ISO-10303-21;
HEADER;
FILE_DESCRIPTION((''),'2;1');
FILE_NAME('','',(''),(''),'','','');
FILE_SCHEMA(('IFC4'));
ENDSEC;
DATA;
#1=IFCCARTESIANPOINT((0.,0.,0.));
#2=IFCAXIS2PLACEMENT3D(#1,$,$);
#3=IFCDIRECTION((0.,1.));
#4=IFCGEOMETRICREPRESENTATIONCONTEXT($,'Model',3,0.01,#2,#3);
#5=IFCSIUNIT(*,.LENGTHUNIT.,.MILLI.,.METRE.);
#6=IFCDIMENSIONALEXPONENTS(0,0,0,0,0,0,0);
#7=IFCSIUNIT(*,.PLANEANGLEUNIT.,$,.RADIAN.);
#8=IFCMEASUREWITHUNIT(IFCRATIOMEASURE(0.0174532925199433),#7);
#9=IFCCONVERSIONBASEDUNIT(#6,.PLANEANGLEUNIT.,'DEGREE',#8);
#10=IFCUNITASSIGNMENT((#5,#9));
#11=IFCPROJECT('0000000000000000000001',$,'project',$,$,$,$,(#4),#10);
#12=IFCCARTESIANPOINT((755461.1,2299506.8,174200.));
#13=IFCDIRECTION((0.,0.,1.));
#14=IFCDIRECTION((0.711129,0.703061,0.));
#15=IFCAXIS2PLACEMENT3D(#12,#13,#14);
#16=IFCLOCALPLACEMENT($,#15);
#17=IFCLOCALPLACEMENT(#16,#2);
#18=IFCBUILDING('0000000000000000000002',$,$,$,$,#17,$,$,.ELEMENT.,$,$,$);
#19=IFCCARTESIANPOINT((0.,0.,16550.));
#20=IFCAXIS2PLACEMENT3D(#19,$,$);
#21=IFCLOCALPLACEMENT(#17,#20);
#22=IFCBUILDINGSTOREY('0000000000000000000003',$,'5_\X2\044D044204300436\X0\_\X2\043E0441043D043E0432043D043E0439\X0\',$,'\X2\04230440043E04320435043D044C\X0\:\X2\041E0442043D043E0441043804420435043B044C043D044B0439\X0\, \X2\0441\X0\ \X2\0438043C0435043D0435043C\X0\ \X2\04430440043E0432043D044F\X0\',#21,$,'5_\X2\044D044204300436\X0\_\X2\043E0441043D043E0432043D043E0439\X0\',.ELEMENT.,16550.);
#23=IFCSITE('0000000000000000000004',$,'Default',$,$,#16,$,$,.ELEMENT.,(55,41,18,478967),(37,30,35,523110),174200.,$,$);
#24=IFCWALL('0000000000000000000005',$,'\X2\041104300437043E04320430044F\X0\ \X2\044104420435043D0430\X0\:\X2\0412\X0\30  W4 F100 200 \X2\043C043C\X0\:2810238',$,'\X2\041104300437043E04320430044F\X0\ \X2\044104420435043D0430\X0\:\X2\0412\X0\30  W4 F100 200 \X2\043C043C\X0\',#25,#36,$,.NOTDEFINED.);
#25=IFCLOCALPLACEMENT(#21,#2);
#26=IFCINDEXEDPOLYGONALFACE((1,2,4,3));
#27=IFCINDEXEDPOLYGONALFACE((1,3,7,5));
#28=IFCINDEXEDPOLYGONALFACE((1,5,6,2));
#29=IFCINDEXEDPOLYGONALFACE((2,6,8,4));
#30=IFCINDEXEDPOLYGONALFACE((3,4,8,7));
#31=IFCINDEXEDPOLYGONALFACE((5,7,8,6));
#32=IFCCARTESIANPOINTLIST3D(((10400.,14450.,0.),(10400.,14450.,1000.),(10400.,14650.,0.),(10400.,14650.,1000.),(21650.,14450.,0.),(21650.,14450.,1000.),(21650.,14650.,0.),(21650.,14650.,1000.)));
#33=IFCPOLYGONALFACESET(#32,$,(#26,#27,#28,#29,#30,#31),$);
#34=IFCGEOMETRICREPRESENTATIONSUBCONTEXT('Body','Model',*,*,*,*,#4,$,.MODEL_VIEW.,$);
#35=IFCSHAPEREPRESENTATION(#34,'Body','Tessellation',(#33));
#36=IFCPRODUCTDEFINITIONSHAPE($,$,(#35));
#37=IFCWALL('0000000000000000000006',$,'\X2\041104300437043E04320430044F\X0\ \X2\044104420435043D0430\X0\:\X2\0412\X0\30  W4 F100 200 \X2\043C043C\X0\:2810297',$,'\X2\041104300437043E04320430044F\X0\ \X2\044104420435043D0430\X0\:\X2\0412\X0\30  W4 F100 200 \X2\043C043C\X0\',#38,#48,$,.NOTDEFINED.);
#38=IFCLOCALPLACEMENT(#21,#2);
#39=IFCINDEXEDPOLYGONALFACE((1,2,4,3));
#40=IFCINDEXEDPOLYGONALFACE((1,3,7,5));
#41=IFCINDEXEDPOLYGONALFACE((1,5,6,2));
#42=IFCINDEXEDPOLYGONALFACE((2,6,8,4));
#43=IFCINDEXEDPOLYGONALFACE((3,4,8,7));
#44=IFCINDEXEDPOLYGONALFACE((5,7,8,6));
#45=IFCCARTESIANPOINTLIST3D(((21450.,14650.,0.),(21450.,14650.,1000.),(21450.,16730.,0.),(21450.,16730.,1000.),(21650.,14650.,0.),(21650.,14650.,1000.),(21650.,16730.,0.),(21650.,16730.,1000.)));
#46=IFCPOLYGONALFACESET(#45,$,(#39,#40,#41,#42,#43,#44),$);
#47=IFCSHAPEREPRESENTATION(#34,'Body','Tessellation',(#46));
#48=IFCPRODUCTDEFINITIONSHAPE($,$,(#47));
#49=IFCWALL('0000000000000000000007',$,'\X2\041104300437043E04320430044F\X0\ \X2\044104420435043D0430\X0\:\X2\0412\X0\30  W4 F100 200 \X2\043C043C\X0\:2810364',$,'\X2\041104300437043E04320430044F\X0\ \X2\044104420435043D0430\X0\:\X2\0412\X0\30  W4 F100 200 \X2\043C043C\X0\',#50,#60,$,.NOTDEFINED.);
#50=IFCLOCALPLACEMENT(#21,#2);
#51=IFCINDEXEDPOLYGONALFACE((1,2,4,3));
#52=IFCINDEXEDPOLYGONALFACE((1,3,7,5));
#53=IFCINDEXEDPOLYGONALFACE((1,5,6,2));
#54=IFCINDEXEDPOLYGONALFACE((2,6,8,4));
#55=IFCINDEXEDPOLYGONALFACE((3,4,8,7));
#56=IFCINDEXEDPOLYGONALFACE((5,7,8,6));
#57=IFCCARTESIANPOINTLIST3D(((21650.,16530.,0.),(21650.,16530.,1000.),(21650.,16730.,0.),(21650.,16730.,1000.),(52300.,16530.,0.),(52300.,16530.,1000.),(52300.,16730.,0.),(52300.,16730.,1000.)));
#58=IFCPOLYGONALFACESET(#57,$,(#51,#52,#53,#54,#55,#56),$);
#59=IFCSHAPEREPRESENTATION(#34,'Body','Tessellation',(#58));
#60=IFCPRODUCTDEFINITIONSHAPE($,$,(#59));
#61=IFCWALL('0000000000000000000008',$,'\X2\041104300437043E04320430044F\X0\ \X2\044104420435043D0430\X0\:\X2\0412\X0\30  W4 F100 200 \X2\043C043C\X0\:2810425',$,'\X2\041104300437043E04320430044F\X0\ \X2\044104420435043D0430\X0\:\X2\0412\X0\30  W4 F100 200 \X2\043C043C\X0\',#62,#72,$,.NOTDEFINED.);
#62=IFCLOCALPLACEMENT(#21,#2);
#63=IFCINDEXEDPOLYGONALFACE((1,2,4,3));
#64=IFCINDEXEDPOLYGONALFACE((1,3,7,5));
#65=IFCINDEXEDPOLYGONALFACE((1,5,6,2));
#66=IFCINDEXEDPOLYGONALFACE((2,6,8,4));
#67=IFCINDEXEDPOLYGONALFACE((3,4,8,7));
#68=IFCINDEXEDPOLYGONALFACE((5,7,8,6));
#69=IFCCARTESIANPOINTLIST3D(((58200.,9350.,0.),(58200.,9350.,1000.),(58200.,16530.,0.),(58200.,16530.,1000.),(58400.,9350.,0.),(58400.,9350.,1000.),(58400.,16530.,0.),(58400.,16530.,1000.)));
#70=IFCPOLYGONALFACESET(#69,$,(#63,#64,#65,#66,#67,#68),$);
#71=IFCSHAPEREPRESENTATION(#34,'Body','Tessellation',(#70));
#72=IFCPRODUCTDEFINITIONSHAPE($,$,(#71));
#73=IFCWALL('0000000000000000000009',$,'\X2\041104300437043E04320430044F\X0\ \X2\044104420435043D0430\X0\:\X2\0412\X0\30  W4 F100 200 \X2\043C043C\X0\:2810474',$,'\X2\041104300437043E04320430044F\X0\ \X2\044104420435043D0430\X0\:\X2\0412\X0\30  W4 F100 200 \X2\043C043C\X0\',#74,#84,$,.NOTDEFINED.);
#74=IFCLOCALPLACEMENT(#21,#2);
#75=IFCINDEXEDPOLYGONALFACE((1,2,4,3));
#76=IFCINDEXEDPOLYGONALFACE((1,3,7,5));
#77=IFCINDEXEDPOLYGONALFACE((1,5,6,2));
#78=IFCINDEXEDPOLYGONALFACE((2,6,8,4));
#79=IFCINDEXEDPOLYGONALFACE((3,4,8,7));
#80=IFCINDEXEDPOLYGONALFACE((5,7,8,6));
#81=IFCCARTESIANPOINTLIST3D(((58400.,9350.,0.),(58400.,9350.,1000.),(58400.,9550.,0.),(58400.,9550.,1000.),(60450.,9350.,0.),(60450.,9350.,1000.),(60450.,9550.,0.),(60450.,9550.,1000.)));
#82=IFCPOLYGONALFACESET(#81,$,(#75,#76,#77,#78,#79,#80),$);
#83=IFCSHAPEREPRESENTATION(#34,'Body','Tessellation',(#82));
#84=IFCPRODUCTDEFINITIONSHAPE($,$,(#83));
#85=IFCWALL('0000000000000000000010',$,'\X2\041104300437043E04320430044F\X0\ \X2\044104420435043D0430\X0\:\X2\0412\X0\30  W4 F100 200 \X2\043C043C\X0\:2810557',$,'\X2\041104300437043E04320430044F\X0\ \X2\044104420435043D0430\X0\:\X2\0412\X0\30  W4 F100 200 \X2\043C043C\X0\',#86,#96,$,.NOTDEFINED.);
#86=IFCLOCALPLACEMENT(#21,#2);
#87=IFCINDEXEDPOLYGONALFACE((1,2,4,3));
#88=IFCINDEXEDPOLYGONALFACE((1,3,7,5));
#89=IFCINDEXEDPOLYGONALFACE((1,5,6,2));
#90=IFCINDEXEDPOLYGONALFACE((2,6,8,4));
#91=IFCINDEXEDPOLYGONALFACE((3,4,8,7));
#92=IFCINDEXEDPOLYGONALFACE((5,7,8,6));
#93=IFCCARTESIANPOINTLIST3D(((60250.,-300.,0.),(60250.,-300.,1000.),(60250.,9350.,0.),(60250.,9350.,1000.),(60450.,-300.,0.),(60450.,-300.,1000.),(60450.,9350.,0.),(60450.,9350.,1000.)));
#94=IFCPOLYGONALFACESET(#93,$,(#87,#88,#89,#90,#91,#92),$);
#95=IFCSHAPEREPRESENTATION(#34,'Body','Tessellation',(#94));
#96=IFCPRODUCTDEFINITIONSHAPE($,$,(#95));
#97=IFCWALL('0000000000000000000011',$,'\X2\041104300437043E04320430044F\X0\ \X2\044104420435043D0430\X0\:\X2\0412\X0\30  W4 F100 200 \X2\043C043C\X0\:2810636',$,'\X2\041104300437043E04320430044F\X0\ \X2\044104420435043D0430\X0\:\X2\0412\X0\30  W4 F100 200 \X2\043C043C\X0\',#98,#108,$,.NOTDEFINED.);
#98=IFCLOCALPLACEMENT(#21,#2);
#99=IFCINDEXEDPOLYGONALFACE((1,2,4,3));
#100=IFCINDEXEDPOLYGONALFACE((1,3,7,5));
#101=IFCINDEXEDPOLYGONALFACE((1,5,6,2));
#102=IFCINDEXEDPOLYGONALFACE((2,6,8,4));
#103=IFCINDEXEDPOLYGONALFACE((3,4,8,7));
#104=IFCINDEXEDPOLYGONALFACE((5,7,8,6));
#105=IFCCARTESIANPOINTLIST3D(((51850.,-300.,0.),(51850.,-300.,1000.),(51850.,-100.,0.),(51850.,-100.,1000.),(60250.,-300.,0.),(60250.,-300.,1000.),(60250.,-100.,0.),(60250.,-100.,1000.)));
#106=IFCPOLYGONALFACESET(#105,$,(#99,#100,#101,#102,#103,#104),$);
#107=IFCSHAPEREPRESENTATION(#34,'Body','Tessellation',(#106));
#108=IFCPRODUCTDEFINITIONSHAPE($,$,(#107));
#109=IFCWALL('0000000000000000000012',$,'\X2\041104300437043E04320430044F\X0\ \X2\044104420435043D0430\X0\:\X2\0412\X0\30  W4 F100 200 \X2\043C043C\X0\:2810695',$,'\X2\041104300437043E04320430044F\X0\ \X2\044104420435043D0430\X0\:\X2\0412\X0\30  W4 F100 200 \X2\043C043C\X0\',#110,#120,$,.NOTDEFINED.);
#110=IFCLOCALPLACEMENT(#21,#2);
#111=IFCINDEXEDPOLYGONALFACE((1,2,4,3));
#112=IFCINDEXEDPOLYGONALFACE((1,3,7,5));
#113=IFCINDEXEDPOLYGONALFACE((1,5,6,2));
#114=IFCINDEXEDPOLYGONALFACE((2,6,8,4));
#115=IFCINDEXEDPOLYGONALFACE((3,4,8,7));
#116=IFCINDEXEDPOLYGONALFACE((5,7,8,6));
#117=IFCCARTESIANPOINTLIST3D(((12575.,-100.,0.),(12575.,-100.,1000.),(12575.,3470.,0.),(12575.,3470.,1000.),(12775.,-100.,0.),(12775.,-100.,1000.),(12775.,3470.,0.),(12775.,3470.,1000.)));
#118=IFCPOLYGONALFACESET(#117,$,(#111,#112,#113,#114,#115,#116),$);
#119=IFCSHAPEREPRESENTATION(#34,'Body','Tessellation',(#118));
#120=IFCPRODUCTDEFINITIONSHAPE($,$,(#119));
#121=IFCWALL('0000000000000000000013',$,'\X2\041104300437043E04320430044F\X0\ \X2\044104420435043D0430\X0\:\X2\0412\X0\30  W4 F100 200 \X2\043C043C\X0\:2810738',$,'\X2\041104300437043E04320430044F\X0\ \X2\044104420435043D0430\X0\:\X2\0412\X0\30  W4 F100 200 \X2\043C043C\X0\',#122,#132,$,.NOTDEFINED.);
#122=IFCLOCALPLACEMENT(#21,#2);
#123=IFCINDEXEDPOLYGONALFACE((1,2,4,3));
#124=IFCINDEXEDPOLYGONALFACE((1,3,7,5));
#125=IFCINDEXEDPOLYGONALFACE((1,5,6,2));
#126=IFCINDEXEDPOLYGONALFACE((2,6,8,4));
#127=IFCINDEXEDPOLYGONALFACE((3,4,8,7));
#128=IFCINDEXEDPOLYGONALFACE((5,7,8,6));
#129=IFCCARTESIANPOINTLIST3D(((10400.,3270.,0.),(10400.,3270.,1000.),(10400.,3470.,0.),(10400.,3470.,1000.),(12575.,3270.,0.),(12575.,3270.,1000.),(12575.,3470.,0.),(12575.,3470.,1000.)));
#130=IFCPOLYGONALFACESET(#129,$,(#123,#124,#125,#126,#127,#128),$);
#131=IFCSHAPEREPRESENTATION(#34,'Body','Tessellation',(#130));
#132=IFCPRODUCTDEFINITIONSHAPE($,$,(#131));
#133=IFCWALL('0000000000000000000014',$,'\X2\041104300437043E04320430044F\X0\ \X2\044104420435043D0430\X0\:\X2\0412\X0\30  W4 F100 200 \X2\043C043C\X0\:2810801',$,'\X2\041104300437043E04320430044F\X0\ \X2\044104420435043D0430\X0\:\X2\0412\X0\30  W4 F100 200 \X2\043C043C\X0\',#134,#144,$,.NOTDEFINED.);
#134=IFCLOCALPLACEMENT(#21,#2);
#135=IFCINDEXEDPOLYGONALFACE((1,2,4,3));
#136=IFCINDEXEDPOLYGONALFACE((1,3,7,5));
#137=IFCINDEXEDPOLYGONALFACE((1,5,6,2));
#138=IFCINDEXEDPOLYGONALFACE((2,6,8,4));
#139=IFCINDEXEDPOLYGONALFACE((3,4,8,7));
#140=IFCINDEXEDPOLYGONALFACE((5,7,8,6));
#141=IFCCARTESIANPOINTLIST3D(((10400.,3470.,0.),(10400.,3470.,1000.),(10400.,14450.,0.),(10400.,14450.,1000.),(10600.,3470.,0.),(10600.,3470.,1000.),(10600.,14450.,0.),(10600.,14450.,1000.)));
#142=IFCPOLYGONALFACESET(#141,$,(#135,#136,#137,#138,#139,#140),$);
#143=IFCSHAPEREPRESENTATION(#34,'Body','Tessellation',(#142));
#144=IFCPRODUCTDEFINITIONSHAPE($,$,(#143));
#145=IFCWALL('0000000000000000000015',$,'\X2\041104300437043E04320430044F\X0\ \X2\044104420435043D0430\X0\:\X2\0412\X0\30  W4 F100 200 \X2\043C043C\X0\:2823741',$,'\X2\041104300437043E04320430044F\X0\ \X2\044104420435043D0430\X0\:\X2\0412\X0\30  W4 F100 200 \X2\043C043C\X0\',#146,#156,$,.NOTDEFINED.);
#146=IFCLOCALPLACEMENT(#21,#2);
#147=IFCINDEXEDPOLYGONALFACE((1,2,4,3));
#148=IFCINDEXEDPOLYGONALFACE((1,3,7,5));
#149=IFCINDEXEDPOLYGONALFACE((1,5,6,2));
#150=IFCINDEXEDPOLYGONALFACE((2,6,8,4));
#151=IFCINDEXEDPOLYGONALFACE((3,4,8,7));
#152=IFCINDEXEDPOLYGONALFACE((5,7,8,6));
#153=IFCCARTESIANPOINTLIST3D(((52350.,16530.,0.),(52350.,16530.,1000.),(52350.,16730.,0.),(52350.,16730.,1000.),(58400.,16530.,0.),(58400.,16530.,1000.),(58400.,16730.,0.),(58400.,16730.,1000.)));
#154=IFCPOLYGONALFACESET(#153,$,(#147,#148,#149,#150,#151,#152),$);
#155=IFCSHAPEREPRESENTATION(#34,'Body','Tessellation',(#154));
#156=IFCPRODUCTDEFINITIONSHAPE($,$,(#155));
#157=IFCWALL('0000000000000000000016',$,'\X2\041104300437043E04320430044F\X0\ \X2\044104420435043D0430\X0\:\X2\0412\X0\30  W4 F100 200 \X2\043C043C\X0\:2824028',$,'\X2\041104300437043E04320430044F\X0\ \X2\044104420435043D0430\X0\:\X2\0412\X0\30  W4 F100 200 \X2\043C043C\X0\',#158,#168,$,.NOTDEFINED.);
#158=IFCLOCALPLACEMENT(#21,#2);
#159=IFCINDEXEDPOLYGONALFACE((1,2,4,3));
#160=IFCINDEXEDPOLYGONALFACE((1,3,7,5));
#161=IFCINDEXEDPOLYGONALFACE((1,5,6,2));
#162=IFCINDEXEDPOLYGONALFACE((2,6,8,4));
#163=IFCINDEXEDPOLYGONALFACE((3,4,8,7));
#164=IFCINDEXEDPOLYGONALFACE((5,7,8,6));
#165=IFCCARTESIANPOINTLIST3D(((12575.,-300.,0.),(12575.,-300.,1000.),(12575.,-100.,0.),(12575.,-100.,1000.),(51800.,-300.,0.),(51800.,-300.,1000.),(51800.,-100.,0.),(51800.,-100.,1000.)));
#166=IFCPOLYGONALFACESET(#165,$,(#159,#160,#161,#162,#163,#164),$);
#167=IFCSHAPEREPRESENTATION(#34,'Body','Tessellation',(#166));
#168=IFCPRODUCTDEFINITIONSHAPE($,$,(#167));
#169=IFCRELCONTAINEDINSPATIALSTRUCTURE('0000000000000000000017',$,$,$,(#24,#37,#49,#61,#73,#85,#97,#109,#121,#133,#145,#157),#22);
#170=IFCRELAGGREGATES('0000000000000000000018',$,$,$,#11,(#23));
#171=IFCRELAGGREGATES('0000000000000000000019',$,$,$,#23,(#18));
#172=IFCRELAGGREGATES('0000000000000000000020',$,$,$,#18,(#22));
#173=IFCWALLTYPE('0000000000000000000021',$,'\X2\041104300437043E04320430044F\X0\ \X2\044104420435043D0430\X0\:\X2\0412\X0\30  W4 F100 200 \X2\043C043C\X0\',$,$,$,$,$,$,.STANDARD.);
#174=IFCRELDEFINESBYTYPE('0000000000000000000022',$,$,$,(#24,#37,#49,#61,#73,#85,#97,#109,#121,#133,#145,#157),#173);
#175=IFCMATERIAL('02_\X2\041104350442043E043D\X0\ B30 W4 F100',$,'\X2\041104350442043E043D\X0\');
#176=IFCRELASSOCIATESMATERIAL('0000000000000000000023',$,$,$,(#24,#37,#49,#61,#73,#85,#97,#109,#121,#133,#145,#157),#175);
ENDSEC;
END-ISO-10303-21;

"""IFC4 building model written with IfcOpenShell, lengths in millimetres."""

from ifc_helpers import new_model, entity, si_unit, converted_unit, direction, frame, origin, place, context, subcontext, project, spatial, indexed_curve, outline, extrude, material, type_object, element, save


model = new_model("IFC4")

# Units and contexts
model_context = context("Model", 3, precision=0.01, world=origin(), true_north=direction((0.0, 1.0)))
body_context = subcontext(model_context, "Body", "Model", "MODEL_VIEW")
ifc_project = project(units=[si_unit("LENGTHUNIT", "METRE", prefix="MILLI"), converted_unit("PLANEANGLEUNIT", "DEGREE", entity("IfcRatioMeasure", 0.0174532925199433), si_unit("PLANEANGLEUNIT", "RADIAN"), dimensions=[0, 0, 0, 0, 0, 0, 0])], contexts=[model_context])

# Site, building, storey
site_placement = place(None, frame((755461.1, 2299506.8, 174200.0), z_axis=(0.0, 0.0, 1.0), x_axis=(0.711129, 0.703061, 0.0)))
site = spatial("IfcSite", under=ifc_project, at=site_placement, Name="Default", CompositionType="ELEMENT", RefLatitude=(55, 41, 18, 478967), RefLongitude=(37, 30, 35, 523110), RefElevation=174200.0)
building_placement = place(site_placement, origin())
building = spatial("IfcBuilding", under=site, at=building_placement, CompositionType="ELEMENT")
storey_placement = place(building_placement, frame((0.0, 0.0, 16550.0)))
storey = spatial("IfcBuildingStorey", under=building, at=storey_placement, Name="5_этаж_основной", ObjectType="Уровень:Относительный, с именем уровня", LongName="5_этаж_основной", CompositionType="ELEMENT", Elevation=16550.0)

# Shared definitions
ifc_material = material(Name="02_Бетон B30 W4 F100", Category="Бетон")

# Walls
wall_type = type_object("IfcWallType", Name="Базовая стена:В30  W4 F100 200 мм", PredefinedType="STANDARD")
wall_1_placement = place(storey_placement, frame((10400.0, 14550.0, 0.0)))
element("IfcWall", 1, at=wall_1_placement, inside=storey, type_object=wall_type, material=ifc_material, Name="Базовая стена:В30  W4 F100 200 мм:2810238", ObjectType="Базовая стена:В30  W4 F100 200 мм", PredefinedType="NOTDEFINED", context=body_context, shape_type="SweptSolid", body=[
    extrude(outline(indexed_curve([(11250.0, 100.0), (0.0, 100.0), (0.0, -100.0), (11250.0, -100.0), (11250.0, 100.0)], self_intersect=False)), origin(), (0.0, 0.0, 1.0), 1000.0),
])
wall_2_placement = place(storey_placement, frame((21550.0, 14650.0, 0.0), z_axis=(0.0, 0.0, 1.0), x_axis=(0.0, 1.0, 0.0)))
element("IfcWall", 2, at=wall_2_placement, inside=storey, type_object=wall_type, material=ifc_material, Name="Базовая стена:В30  W4 F100 200 мм:2810297", ObjectType="Базовая стена:В30  W4 F100 200 мм", PredefinedType="NOTDEFINED", context=body_context, shape_type="SweptSolid", body=[
    extrude(outline(indexed_curve([(2080.0, 100.0), (0.0, 100.0), (0.0, -100.0), (2080.0, -100.0), (2080.0, 100.0)], self_intersect=False)), origin(), (0.0, 0.0, 1.0), 1000.0),
])
wall_3_placement = place(storey_placement, frame((21650.0, 16630.0, 0.0)))
element("IfcWall", 3, at=wall_3_placement, inside=storey, type_object=wall_type, material=ifc_material, Name="Базовая стена:В30  W4 F100 200 мм:2810364", ObjectType="Базовая стена:В30  W4 F100 200 мм", PredefinedType="NOTDEFINED", context=body_context, shape_type="SweptSolid", body=[
    extrude(outline(indexed_curve([(30650.0, 100.0), (0.0, 100.0), (0.0, -100.0), (30650.0, -100.0), (30650.0, 100.0)], self_intersect=False)), origin(), (0.0, 0.0, 1.0), 1000.0),
])
wall_4_placement = place(storey_placement, frame((58300.0, 16530.0, 0.0), z_axis=(0.0, 0.0, 1.0), x_axis=(0.0, -1.0, 0.0)))
element("IfcWall", 4, at=wall_4_placement, inside=storey, type_object=wall_type, material=ifc_material, Name="Базовая стена:В30  W4 F100 200 мм:2810425", ObjectType="Базовая стена:В30  W4 F100 200 мм", PredefinedType="NOTDEFINED", context=body_context, shape_type="SweptSolid", body=[
    extrude(outline(indexed_curve([(7180.0, 100.0), (0.0, 100.0), (0.0, -100.0), (7180.0, -100.0), (7180.0, 100.0)], self_intersect=False)), origin(), (0.0, 0.0, 1.0), 1000.0),
])
wall_5_placement = place(storey_placement, frame((58400.0, 9450.0, 0.0)))
element("IfcWall", 5, at=wall_5_placement, inside=storey, type_object=wall_type, material=ifc_material, Name="Базовая стена:В30  W4 F100 200 мм:2810474", ObjectType="Базовая стена:В30  W4 F100 200 мм", PredefinedType="NOTDEFINED", context=body_context, shape_type="SweptSolid", body=[
    extrude(outline(indexed_curve([(2050.0, 100.0), (0.0, 100.0), (0.0, -100.0), (2050.0, -100.0), (2050.0, 100.0)], self_intersect=False)), origin(), (0.0, 0.0, 1.0), 1000.0),
])
wall_6_placement = place(storey_placement, frame((60350.0, 9350.0, 0.0), z_axis=(0.0, 0.0, 1.0), x_axis=(0.0, -1.0, 0.0)))
element("IfcWall", 6, at=wall_6_placement, inside=storey, type_object=wall_type, material=ifc_material, Name="Базовая стена:В30  W4 F100 200 мм:2810557", ObjectType="Базовая стена:В30  W4 F100 200 мм", PredefinedType="NOTDEFINED", context=body_context, shape_type="SweptSolid", body=[
    extrude(outline(indexed_curve([(9650.0, 100.0), (0.0, 100.0), (0.0, -100.0), (9650.0, -100.0), (9650.0, 100.0)], self_intersect=False)), origin(), (0.0, 0.0, 1.0), 1000.0),
])
wall_7_placement = place(storey_placement, frame((60250.0, -200.0, 0.0), z_axis=(0.0, 0.0, 1.0), x_axis=(-1.0, 0.0, 0.0)))
element("IfcWall", 7, at=wall_7_placement, inside=storey, type_object=wall_type, material=ifc_material, Name="Базовая стена:В30  W4 F100 200 мм:2810636", ObjectType="Базовая стена:В30  W4 F100 200 мм", PredefinedType="NOTDEFINED", context=body_context, shape_type="SweptSolid", body=[
    extrude(outline(indexed_curve([(8400.0, 100.0), (0.0, 100.0), (0.0, -100.0), (8400.0, -100.0), (8400.0, 100.0)], self_intersect=False)), origin(), (0.0, 0.0, 1.0), 1000.0),
])
wall_8_placement = place(storey_placement, frame((12675.0, -100.0, 0.0), z_axis=(0.0, 0.0, 1.0), x_axis=(0.0, 1.0, 0.0)))
element("IfcWall", 8, at=wall_8_placement, inside=storey, type_object=wall_type, material=ifc_material, Name="Базовая стена:В30  W4 F100 200 мм:2810695", ObjectType="Базовая стена:В30  W4 F100 200 мм", PredefinedType="NOTDEFINED", context=body_context, shape_type="SweptSolid", body=[
    extrude(outline(indexed_curve([(3570.0, 100.0), (0.0, 100.0), (0.0, -100.0), (3570.0, -100.0), (3570.0, 100.0)], self_intersect=False)), origin(), (0.0, 0.0, 1.0), 1000.0),
])
wall_9_placement = place(storey_placement, frame((12575.0, 3370.0, 0.0), z_axis=(0.0, 0.0, 1.0), x_axis=(-1.0, 0.0, 0.0)))
element("IfcWall", 9, at=wall_9_placement, inside=storey, type_object=wall_type, material=ifc_material, Name="Базовая стена:В30  W4 F100 200 мм:2810738", ObjectType="Базовая стена:В30  W4 F100 200 мм", PredefinedType="NOTDEFINED", context=body_context, shape_type="SweptSolid", body=[
    extrude(outline(indexed_curve([(2175.0, 100.0), (0.0, 100.0), (0.0, -100.0), (2175.0, -100.0), (2175.0, 100.0)], self_intersect=False)), origin(), (0.0, 0.0, 1.0), 1000.0),
])
wall_10_placement = place(storey_placement, frame((10500.0, 3470.0, 0.0), z_axis=(0.0, 0.0, 1.0), x_axis=(0.0, 1.0, 0.0)))
element("IfcWall", 10, at=wall_10_placement, inside=storey, type_object=wall_type, material=ifc_material, Name="Базовая стена:В30  W4 F100 200 мм:2810801", ObjectType="Базовая стена:В30  W4 F100 200 мм", PredefinedType="NOTDEFINED", context=body_context, shape_type="SweptSolid", body=[
    extrude(outline(indexed_curve([(10980.0, 100.0), (0.0, 100.0), (0.0, -100.0), (10980.0, -100.0), (10980.0, 100.0)], self_intersect=False)), origin(), (0.0, 0.0, 1.0), 1000.0),
])
wall_11_placement = place(storey_placement, frame((52350.0, 16630.0, 0.0)))
element("IfcWall", 11, at=wall_11_placement, inside=storey, type_object=wall_type, material=ifc_material, Name="Базовая стена:В30  W4 F100 200 мм:2823741", ObjectType="Базовая стена:В30  W4 F100 200 мм", PredefinedType="NOTDEFINED", context=body_context, shape_type="SweptSolid", body=[
    extrude(outline(indexed_curve([(6050.0, 100.0), (0.0, 100.0), (0.0, -100.0), (6050.0, -100.0), (6050.0, 100.0)], self_intersect=False)), origin(), (0.0, 0.0, 1.0), 1000.0),
])
wall_12_placement = place(storey_placement, frame((51800.0, -200.0, 0.0), z_axis=(0.0, 0.0, 1.0), x_axis=(-1.0, 0.0, 0.0)))
element("IfcWall", 12, at=wall_12_placement, inside=storey, type_object=wall_type, material=ifc_material, Name="Базовая стена:В30  W4 F100 200 мм:2824028", ObjectType="Базовая стена:В30  W4 F100 200 мм", PredefinedType="NOTDEFINED", context=body_context, shape_type="SweptSolid", body=[
    extrude(outline(indexed_curve([(39225.0, 100.0), (0.0, 100.0), (0.0, -100.0), (39225.0, -100.0), (39225.0, 100.0)], self_intersect=False)), origin(), (0.0, 0.0, 1.0), 1000.0),
])

save(model, "model.ifc")
